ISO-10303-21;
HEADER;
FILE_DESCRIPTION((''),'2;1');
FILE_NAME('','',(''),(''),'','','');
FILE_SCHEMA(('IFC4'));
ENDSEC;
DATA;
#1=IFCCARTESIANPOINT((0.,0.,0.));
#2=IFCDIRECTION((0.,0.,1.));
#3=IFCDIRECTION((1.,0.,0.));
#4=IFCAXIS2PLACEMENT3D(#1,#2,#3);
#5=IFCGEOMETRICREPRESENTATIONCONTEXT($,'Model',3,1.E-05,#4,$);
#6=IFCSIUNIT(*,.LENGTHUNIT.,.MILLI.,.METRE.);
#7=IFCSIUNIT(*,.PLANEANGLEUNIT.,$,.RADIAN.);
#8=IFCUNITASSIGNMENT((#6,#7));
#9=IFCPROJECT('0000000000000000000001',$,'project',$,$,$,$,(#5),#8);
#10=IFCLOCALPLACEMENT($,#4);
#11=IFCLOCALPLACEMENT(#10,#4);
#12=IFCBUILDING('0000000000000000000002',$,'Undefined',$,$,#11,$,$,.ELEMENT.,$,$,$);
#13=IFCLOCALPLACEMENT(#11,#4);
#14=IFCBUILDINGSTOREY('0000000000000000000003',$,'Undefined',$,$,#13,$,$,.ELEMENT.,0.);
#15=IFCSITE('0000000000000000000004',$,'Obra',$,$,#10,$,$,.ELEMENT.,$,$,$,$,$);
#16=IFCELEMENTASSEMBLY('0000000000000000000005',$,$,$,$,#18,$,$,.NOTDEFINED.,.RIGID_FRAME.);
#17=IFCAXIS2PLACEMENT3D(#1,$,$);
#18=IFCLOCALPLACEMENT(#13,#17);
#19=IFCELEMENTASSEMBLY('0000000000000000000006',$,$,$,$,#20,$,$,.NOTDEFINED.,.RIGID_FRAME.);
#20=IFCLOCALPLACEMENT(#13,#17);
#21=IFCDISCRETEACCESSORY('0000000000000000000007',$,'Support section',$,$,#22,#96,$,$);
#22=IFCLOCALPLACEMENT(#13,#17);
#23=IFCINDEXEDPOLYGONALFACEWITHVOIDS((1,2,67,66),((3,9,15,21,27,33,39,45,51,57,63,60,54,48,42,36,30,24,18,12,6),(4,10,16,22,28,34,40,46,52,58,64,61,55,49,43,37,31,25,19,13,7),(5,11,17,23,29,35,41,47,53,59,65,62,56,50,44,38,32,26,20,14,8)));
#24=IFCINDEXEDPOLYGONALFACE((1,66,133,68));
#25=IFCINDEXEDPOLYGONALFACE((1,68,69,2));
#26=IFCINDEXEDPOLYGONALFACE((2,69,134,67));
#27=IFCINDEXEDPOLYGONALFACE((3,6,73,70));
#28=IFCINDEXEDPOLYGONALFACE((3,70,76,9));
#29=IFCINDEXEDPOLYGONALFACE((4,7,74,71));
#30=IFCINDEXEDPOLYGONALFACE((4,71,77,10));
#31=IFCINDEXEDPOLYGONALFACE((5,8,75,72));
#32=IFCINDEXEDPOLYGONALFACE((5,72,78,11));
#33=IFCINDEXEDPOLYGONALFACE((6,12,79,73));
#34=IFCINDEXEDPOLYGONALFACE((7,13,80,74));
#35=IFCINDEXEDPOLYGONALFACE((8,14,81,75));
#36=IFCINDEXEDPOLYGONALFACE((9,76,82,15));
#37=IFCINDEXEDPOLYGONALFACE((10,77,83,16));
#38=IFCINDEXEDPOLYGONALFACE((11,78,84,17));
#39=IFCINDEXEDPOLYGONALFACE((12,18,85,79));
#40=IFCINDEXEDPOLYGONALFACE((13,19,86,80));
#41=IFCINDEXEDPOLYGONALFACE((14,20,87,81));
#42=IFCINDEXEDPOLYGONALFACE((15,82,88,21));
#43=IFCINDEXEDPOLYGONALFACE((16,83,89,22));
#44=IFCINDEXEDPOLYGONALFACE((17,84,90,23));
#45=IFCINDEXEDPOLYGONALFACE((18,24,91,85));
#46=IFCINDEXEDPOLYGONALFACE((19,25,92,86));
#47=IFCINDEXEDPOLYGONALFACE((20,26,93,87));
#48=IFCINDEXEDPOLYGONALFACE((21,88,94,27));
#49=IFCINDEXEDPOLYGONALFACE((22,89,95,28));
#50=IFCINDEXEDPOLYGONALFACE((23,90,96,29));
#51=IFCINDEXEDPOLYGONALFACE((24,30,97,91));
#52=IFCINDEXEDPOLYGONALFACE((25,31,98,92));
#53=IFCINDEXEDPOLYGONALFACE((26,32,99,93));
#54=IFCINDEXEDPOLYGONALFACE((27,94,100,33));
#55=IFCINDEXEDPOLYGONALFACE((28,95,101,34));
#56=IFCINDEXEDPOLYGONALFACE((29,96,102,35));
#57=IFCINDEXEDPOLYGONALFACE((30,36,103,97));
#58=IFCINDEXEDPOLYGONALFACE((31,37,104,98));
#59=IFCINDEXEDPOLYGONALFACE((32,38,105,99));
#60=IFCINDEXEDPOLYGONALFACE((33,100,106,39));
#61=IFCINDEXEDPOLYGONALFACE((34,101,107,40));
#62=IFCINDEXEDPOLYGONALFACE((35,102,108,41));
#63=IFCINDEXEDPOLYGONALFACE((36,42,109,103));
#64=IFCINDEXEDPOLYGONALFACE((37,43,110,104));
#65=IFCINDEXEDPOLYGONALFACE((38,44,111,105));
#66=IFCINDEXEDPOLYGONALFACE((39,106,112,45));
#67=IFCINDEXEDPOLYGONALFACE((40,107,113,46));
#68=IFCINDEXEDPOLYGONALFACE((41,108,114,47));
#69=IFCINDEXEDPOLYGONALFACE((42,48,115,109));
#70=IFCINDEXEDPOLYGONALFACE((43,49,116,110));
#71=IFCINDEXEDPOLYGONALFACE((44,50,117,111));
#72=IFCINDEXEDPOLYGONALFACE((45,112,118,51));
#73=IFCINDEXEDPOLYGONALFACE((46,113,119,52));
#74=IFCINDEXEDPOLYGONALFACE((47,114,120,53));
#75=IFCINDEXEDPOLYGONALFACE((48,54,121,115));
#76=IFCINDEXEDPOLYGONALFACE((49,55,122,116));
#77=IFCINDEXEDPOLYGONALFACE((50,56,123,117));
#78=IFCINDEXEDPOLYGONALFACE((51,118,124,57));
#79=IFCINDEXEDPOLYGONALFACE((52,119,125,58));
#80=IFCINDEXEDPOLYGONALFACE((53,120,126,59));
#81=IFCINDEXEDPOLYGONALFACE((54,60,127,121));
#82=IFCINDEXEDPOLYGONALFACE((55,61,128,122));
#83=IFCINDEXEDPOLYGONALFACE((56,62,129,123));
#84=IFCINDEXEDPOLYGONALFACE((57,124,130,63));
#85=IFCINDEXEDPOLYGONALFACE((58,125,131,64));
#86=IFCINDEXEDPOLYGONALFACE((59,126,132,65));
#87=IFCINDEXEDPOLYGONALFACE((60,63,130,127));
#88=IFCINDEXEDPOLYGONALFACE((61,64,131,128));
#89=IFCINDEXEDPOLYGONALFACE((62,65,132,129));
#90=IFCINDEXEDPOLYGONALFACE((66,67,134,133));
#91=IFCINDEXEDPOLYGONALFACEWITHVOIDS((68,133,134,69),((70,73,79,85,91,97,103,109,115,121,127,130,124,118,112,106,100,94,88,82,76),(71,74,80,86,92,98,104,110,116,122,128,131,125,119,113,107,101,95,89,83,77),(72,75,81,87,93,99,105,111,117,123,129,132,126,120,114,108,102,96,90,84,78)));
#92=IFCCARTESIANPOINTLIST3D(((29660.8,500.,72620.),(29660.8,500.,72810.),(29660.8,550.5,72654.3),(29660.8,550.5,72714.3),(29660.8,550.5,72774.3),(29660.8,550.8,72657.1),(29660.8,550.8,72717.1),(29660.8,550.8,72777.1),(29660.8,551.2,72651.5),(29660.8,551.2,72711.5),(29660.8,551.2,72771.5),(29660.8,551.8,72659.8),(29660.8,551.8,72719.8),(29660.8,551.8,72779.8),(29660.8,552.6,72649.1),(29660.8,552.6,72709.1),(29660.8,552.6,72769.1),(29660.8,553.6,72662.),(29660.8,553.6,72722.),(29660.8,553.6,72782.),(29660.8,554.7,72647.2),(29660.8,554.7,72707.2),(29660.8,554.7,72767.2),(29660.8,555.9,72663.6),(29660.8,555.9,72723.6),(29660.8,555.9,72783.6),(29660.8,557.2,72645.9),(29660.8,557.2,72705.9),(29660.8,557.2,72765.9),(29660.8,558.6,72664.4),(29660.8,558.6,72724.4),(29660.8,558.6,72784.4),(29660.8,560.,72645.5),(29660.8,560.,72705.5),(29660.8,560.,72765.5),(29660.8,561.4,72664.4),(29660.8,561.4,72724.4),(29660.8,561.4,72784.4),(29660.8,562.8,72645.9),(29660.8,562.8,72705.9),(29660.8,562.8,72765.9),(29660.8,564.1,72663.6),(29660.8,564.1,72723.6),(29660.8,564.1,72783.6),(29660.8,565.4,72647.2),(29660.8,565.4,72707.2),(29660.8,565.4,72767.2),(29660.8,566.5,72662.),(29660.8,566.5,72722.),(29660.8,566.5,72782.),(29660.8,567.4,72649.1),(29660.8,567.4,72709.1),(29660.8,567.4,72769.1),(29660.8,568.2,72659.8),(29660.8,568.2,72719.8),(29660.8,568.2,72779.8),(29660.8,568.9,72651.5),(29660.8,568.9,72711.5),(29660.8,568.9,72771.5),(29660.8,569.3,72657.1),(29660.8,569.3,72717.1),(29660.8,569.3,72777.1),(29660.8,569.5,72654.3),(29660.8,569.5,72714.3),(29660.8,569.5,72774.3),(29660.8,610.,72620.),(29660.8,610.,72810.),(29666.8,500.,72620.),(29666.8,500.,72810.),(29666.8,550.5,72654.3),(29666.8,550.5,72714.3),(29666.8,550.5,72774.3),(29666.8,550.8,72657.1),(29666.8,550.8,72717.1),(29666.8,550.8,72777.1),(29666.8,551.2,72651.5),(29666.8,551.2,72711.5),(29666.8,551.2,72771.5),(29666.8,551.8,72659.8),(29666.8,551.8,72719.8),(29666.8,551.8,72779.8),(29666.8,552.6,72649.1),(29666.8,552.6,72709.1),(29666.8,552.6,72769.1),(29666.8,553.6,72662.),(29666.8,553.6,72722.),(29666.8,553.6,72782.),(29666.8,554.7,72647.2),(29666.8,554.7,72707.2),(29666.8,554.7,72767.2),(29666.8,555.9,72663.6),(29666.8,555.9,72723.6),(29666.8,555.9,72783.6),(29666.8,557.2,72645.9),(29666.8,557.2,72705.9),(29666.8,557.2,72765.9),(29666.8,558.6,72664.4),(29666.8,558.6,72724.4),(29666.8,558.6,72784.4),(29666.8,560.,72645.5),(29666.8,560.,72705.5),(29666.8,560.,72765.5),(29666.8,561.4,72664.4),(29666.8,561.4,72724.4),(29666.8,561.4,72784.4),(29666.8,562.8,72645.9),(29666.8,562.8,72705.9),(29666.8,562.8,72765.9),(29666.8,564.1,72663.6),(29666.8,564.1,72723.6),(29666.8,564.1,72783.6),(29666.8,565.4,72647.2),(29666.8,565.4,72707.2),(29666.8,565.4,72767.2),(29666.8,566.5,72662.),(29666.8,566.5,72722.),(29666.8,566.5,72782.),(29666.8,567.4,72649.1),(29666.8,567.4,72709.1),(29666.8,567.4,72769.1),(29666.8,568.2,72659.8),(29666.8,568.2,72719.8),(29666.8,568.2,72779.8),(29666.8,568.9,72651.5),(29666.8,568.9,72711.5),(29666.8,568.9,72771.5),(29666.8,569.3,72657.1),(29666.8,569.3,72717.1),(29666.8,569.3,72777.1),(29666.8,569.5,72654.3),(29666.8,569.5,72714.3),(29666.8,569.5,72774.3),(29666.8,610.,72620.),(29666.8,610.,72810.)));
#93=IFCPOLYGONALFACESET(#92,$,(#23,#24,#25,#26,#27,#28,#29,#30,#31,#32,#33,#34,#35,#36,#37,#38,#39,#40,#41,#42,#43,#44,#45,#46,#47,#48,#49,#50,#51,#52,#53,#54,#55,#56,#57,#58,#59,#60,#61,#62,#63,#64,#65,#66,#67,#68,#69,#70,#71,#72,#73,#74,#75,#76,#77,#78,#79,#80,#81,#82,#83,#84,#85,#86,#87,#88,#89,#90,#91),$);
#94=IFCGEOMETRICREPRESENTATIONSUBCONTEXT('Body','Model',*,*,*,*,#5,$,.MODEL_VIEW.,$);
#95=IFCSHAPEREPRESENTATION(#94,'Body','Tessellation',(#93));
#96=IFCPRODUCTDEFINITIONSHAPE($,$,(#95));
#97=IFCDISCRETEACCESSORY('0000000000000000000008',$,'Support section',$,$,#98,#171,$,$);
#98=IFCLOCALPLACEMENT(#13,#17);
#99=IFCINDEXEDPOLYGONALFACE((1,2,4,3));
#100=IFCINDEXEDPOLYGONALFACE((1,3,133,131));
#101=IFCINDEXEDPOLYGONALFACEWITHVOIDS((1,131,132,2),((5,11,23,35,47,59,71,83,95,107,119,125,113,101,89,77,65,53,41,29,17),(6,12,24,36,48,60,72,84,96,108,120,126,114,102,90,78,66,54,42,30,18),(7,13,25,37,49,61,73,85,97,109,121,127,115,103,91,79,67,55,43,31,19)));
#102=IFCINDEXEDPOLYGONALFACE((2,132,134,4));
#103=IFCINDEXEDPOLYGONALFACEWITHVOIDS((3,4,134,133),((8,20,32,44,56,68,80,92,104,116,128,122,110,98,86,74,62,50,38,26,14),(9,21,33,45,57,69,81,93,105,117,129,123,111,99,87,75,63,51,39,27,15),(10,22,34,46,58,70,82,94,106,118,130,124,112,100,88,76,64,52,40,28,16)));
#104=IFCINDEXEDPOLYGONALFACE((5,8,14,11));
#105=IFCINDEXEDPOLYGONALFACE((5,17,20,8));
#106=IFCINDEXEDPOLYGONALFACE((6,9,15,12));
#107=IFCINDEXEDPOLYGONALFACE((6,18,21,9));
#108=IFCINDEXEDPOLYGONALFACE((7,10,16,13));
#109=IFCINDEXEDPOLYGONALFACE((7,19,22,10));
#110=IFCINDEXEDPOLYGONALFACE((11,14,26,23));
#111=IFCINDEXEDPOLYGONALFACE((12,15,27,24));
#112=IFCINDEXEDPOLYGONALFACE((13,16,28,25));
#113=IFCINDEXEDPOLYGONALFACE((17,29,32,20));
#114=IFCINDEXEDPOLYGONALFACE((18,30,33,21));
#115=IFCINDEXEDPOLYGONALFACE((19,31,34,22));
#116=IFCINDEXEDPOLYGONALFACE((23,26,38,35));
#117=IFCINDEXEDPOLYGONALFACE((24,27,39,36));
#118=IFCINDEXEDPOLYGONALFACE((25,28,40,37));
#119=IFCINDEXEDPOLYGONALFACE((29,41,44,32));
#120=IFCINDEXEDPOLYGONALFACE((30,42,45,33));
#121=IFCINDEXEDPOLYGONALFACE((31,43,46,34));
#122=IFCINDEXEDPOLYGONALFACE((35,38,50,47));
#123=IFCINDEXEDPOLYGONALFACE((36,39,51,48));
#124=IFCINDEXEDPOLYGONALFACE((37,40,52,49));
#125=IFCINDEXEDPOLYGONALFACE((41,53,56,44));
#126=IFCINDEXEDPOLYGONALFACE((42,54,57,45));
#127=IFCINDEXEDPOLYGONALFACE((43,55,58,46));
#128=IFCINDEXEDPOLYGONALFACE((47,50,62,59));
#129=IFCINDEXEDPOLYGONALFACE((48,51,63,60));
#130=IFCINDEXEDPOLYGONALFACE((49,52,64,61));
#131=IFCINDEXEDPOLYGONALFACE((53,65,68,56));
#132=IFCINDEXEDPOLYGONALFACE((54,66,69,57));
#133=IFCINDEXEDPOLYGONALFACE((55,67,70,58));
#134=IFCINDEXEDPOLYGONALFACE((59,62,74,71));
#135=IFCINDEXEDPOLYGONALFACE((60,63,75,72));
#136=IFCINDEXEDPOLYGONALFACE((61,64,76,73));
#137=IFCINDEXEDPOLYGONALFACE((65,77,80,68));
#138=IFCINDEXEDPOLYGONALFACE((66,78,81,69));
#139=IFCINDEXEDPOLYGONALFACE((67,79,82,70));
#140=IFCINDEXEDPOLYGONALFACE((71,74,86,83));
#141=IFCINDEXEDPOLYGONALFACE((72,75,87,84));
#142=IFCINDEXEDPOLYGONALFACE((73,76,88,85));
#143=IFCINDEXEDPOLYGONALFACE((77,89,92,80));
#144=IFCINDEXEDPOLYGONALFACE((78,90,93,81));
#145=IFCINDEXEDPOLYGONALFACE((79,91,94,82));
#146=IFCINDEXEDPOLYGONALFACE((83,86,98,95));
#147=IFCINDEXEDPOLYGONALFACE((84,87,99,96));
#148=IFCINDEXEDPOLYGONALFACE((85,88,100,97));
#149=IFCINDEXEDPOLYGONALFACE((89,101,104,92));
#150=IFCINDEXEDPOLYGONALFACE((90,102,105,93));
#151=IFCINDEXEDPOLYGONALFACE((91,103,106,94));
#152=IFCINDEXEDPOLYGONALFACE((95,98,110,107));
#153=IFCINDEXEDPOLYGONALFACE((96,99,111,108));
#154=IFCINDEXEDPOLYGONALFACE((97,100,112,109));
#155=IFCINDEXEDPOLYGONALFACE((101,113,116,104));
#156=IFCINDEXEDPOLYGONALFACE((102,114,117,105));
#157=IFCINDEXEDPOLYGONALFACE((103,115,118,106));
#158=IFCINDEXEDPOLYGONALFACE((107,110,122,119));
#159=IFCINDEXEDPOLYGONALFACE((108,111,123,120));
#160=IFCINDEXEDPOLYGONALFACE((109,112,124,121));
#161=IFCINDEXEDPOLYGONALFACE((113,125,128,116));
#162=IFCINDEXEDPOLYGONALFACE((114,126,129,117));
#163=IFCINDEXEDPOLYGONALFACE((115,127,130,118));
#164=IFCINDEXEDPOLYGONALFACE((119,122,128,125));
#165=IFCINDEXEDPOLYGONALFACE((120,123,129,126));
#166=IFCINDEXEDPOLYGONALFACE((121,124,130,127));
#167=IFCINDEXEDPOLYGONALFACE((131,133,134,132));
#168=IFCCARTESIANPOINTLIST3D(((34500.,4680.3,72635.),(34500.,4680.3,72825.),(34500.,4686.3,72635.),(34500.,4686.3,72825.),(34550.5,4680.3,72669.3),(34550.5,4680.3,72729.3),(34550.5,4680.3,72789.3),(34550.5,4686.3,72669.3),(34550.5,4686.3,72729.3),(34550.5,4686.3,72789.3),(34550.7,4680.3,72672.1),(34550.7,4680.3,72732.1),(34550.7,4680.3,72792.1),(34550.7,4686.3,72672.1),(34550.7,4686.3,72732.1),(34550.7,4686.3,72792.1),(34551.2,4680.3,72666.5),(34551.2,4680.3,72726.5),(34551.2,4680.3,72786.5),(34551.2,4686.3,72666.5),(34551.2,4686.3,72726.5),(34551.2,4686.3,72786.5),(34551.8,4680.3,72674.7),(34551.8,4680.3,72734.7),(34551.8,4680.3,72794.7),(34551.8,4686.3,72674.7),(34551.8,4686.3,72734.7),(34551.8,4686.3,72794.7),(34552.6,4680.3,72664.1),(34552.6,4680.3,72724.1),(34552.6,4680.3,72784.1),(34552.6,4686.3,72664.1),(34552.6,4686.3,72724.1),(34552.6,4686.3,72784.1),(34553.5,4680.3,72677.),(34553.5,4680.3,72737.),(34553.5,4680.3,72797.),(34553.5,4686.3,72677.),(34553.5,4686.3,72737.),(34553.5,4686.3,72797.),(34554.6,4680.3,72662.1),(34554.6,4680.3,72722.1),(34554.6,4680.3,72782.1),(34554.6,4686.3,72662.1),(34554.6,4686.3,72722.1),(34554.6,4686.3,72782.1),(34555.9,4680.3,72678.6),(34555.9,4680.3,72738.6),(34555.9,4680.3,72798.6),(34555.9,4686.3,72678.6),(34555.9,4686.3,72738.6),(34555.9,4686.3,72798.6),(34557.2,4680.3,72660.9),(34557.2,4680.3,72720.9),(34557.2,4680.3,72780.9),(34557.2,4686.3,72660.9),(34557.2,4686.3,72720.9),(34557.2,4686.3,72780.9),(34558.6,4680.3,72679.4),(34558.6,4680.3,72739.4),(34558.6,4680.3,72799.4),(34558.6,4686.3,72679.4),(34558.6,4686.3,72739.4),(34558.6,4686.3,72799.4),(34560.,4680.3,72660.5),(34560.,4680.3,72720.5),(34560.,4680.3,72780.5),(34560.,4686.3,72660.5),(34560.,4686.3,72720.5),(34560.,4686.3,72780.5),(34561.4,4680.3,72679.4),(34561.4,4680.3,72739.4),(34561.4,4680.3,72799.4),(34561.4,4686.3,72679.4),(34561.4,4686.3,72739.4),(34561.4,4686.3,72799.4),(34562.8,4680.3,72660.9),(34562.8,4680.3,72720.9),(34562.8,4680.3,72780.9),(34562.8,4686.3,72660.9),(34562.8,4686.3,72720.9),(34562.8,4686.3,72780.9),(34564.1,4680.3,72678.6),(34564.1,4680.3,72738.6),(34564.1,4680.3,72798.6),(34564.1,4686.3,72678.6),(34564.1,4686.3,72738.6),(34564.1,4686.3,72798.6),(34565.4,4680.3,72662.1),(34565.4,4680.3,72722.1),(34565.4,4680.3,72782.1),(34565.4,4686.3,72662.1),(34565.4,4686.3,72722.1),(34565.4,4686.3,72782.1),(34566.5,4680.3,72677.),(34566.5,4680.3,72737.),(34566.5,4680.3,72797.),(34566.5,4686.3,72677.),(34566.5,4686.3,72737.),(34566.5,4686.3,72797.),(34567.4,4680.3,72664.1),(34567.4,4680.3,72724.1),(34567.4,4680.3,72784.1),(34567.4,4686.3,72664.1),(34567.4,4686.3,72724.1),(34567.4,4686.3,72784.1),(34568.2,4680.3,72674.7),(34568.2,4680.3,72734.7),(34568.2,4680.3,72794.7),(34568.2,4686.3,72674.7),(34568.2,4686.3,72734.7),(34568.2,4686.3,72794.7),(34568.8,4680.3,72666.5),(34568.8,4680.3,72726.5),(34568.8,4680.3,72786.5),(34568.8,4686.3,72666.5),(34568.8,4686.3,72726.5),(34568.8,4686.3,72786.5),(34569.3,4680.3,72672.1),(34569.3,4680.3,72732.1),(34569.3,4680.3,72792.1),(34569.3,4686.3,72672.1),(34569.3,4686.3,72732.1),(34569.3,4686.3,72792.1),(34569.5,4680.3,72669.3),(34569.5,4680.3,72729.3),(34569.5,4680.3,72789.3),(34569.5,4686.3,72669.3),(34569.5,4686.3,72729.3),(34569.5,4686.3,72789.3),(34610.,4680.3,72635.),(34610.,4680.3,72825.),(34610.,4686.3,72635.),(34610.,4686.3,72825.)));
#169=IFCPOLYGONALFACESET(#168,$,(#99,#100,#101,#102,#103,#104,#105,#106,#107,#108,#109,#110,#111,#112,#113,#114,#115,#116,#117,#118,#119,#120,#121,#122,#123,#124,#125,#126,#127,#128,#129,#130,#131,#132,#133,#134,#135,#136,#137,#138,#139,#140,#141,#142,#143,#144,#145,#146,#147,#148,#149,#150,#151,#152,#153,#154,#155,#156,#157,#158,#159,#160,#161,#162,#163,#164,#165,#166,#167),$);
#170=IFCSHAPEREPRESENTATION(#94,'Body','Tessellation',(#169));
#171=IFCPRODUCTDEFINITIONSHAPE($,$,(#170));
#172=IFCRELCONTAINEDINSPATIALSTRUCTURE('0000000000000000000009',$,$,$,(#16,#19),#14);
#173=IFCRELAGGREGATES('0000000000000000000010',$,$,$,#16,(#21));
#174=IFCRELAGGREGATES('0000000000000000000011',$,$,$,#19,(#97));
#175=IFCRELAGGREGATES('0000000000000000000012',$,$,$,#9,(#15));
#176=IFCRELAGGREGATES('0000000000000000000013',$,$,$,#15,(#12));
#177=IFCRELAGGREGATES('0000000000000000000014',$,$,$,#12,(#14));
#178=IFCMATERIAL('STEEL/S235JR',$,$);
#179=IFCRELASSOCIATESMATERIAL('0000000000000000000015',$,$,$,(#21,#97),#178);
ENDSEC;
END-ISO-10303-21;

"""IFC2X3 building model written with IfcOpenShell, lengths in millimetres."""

from ifc_helpers import new_model, si_unit, frame, origin_with_axes, origin_2d_with_axis, place, context, subcontext, project, spatial, rectangle, circle, extrude, source, transform, mapped, material, element, aggregate, save


model = new_model("IFC2X3")

# Units and contexts
model_context = context("Model", 3, precision=1e-05, world=origin_with_axes())
body_context = subcontext(model_context, "Body", "Model", "MODEL_VIEW")
ifc_project = project(units=[si_unit("LENGTHUNIT", "METRE", prefix="MILLI"), si_unit("PLANEANGLEUNIT", "RADIAN")], contexts=[model_context])

# Site, building, storey
site_placement = place(None, origin_with_axes())
site = spatial("IfcSite", under=ifc_project, at=site_placement, Name="Obra", CompositionType="ELEMENT")
building_placement = place(site_placement, origin_with_axes())
building = spatial("IfcBuilding", under=site, at=building_placement, Name="Undefined", CompositionType="ELEMENT")
storey_placement = place(building_placement, origin_with_axes())
storey = spatial("IfcBuildingStorey", under=building, at=storey_placement, Name="Undefined", CompositionType="ELEMENT", Elevation=0.0)

# Element assemblies
assembly_1_placement = place(storey_placement, origin_with_axes())
assembly_1 = element("IfcElementAssembly", 1, at=assembly_1_placement, inside=storey, AssemblyPlace="NOTDEFINED", PredefinedType="RIGID_FRAME")
ifc_material_1 = material(Name="STEEL/S235JR")
assembly_2_placement = place(storey_placement, origin_with_axes())
assembly_2 = element("IfcElementAssembly", 2, at=assembly_2_placement, inside=storey, AssemblyPlace="NOTDEFINED", PredefinedType="RIGID_FRAME")

# Discrete accessories, openings
discrete_accessory_1_placement = place(assembly_1_placement, frame((29663.8, 555.0, 72620.0), z_axis=(0.0, 0.0, 1.0), x_axis=(0.000002, -1.0, 0.0)))
discrete_accessory_1 = element("IfcDiscreteAccessory", 3, at=discrete_accessory_1_placement, material=ifc_material_1, Name="Support section", context=body_context, shape_type="SweptSolid", body=[
    extrude(rectangle(XDim=6.0, YDim=110.0, at=origin_2d_with_axis()), frame((0.0, 0.0, 190.0), z_axis=(0.0, 0.0, -1.0), x_axis=(0.0, 1.0, 0.0)), (0.0, 0.0, 1.0), 190.0),
])
shared_shape_1 = source(origin_with_axes(), body_context, "Body", "SweptSolid", [
    extrude(circle(Radius=9.5, at=origin_2d_with_axis()), frame((0.0, -9.2, 0.0), z_axis=(0.0, 1.0, 0.0), x_axis=(1.0, 0.0, 0.0)), (0.0, 0.0, 1.0), 6.2),
])
opening_1_placement = place(assembly_1_placement, frame((29657.7, 510.0, 72835.0), z_axis=(-0.000002, 1.0, 0.0), x_axis=(0.0, 0.0, -1.0)))
element("IfcOpeningElement", 4, at=opening_1_placement, cuts=discrete_accessory_1, ObjectType="Opening", context=body_context, shape_type="MappedRepresentation", body=[
    mapped(shared_shape_1, transform((60.0, 0.0, 50.0))),
    mapped(shared_shape_1, transform((120.0, 0.0, 50.0))),
    mapped(shared_shape_1, transform((180.0, 0.0, 50.0))),
])
aggregate(assembly_1, [discrete_accessory_1])
discrete_accessory_2_placement = place(assembly_2_placement, frame((34555.0, 4683.3, 72635.0), z_axis=(0.0, 0.0, 1.0), x_axis=(-1.0, 0.0, 0.0)))
discrete_accessory_2 = element("IfcDiscreteAccessory", 5, at=discrete_accessory_2_placement, material=ifc_material_1, Name="Support section", context=body_context, shape_type="SweptSolid", body=[
    extrude(rectangle(XDim=6.0, YDim=110.0, at=origin_2d_with_axis()), frame((0.0, 0.0, 190.0), z_axis=(0.0, 0.0, -1.0), x_axis=(0.0, 1.0, 0.0)), (0.0, 0.0, 1.0), 190.0),
])
opening_2_placement = place(assembly_2_placement, frame((34510.0, 4689.4, 72850.0), z_axis=(1.0, 0.0, 0.0), x_axis=(0.0, 0.0, -1.0)))
element("IfcOpeningElement", 6, at=opening_2_placement, cuts=discrete_accessory_2, ObjectType="Opening", context=body_context, shape_type="MappedRepresentation", body=[
    mapped(shared_shape_1, transform((60.0, 0.0, 50.0))),
    mapped(shared_shape_1, transform((120.0, 0.0, 50.0))),
    mapped(shared_shape_1, transform((180.0, 0.0, 50.0))),
])
aggregate(assembly_2, [discrete_accessory_2])

save(model, "model.ifc")
